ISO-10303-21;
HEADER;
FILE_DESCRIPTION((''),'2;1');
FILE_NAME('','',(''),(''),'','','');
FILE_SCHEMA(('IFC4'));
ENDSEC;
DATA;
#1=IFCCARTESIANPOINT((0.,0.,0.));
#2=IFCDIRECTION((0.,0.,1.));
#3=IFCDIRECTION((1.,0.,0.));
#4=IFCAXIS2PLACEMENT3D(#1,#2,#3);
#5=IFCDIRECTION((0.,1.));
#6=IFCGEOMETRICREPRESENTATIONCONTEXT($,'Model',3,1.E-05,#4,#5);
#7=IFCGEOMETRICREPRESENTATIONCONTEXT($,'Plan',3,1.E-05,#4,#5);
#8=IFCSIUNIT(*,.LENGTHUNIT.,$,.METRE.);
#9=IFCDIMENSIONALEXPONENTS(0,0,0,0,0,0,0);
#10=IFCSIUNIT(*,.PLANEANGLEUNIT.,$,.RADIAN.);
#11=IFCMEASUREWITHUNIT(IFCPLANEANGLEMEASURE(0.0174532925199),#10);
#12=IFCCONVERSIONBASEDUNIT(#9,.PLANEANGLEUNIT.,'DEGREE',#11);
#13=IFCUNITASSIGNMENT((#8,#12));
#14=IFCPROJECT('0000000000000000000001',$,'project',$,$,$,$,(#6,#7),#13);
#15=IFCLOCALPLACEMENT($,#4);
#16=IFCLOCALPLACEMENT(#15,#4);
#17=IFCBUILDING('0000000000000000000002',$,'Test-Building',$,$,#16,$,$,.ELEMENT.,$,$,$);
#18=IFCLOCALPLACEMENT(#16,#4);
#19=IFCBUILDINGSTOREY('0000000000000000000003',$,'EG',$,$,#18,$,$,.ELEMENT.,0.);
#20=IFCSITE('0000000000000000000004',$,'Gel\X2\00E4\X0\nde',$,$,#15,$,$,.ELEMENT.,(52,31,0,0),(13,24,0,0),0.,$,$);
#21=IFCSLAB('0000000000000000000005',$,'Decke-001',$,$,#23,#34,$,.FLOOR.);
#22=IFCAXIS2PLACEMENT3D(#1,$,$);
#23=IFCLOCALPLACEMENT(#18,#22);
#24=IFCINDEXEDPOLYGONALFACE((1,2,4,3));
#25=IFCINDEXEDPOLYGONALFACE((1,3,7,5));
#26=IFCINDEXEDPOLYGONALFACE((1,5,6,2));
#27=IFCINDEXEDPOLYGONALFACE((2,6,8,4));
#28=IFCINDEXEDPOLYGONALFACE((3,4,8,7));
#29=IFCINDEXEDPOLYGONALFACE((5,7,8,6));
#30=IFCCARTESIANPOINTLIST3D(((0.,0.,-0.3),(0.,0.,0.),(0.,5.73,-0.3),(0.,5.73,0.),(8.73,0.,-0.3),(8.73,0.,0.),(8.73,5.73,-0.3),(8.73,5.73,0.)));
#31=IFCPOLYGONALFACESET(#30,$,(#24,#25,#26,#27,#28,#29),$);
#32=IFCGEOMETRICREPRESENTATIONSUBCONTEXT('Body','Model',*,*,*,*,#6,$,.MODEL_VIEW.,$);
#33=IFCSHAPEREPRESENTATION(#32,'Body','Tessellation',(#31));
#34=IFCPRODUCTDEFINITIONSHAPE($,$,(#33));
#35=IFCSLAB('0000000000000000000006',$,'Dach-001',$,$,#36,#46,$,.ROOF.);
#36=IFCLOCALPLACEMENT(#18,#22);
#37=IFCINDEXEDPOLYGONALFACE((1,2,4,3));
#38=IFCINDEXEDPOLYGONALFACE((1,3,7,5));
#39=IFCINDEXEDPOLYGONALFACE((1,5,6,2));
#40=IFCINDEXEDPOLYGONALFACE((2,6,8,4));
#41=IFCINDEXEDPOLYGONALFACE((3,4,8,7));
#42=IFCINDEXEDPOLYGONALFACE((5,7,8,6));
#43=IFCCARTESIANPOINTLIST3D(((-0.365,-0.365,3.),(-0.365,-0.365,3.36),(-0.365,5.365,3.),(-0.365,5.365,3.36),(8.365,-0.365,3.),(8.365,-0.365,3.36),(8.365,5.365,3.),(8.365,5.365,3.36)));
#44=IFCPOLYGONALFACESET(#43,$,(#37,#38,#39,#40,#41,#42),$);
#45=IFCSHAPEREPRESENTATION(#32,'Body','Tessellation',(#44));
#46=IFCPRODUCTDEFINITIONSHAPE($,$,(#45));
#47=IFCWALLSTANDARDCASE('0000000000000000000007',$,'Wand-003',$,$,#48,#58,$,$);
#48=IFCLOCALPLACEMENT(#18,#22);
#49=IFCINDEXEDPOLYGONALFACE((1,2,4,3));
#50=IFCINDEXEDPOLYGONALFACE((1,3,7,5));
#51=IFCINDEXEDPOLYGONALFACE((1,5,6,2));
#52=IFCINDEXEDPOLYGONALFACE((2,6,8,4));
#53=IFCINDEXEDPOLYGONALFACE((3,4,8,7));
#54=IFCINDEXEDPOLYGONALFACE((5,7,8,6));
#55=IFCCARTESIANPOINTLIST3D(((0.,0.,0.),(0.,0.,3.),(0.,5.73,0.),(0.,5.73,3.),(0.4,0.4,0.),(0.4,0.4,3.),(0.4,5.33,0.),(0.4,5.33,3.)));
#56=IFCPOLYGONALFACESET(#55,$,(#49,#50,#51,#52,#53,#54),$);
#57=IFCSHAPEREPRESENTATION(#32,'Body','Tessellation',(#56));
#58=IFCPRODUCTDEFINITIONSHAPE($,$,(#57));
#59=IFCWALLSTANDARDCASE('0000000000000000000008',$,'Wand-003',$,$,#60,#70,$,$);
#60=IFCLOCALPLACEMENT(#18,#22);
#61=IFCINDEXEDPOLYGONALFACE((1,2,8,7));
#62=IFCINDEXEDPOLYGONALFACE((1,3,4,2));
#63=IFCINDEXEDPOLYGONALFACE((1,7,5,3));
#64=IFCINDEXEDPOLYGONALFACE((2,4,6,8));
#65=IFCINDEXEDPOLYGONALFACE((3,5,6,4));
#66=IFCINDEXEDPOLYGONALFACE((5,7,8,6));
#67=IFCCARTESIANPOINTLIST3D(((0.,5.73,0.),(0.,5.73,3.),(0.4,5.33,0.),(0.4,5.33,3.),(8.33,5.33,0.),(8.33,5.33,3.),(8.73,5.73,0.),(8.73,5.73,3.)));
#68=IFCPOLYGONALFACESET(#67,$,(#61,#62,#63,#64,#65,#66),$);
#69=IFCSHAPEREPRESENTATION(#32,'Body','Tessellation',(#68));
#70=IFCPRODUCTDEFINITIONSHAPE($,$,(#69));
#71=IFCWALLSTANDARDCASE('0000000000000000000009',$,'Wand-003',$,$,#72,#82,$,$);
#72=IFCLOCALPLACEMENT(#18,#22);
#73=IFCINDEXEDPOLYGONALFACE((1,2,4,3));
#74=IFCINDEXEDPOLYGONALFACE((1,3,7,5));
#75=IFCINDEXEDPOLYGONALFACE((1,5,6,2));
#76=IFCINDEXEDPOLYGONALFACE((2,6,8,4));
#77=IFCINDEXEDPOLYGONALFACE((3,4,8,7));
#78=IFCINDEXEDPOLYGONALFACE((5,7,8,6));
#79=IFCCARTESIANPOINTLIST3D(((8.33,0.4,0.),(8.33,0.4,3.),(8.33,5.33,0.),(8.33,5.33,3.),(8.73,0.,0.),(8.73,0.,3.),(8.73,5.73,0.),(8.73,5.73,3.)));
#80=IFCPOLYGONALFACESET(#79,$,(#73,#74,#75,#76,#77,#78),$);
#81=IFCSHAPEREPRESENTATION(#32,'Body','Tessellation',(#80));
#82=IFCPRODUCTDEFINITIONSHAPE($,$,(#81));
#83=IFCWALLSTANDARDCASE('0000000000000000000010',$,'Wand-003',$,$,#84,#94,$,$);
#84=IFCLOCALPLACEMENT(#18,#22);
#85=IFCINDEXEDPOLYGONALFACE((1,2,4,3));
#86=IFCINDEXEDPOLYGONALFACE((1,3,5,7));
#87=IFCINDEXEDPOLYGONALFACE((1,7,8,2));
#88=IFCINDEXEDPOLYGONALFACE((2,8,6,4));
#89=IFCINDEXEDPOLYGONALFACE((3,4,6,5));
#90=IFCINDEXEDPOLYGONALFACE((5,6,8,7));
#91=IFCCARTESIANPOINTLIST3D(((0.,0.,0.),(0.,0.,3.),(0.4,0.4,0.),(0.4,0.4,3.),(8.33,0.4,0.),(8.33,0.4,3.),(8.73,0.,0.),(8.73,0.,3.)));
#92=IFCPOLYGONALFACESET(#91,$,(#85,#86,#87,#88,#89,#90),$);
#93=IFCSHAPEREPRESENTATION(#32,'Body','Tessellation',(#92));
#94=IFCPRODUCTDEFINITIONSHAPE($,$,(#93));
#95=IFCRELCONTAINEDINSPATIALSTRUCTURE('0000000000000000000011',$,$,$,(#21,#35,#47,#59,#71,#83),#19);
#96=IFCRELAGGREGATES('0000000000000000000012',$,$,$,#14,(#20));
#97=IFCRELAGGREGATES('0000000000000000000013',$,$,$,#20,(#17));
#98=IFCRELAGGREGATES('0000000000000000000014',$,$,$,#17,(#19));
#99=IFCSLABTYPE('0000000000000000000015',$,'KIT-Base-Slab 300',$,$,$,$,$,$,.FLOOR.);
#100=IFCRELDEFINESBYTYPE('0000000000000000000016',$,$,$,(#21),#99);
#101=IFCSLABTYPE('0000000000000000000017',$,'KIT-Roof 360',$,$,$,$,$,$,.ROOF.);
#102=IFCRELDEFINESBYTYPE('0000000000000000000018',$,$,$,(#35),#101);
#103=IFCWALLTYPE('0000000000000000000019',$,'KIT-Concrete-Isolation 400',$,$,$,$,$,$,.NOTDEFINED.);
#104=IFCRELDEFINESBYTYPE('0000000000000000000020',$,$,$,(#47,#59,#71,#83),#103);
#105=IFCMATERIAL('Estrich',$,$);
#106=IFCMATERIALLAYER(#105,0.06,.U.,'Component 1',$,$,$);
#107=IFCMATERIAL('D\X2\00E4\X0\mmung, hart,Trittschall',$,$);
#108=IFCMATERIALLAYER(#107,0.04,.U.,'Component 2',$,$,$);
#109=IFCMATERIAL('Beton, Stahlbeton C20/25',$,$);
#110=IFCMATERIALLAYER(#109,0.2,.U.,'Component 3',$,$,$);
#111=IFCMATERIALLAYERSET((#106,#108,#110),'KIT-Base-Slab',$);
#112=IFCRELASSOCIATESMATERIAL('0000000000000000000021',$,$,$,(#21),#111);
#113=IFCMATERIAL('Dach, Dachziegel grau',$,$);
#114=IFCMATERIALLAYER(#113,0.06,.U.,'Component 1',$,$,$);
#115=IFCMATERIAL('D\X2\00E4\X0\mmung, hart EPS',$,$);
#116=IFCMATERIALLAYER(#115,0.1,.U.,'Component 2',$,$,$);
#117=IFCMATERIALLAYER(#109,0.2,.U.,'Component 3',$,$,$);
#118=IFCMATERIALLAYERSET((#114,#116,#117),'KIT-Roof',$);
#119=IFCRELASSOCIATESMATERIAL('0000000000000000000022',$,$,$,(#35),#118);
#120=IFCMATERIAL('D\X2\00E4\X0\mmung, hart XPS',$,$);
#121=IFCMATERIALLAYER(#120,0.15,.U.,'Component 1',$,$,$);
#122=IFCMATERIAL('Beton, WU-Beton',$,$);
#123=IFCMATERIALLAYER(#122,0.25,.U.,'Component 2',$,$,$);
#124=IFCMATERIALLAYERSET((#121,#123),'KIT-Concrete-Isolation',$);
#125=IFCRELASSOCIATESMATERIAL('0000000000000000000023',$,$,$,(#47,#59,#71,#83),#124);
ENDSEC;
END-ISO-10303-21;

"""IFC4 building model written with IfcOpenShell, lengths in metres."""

from ifc_helpers import new_model, entity, si_unit, converted_unit, direction, frame, origin_with_axes, place, context, subcontext, project, spatial, polyline, outline, extrude, material, layer, layer_set, layer_usage, type_object, element, save


model = new_model("IFC4")

# Units and contexts
model_context = context("Model", 3, precision=1e-05, world=origin_with_axes(), true_north=direction((0.0, 1.0)))
plan_context = context("Plan", 3, precision=1e-05, world=origin_with_axes(), true_north=direction((0.0, 1.0)))
body_context = subcontext(model_context, "Body", "Model", "MODEL_VIEW")
ifc_project = project(units=[si_unit("LENGTHUNIT", "METRE"), converted_unit("PLANEANGLEUNIT", "DEGREE", entity("IfcPlaneAngleMeasure", 0.0174532925199), si_unit("PLANEANGLEUNIT", "RADIAN"), dimensions=[0, 0, 0, 0, 0, 0, 0])], contexts=[model_context, plan_context])

# Site, building, storey
site_placement = place(None, origin_with_axes())
site = spatial("IfcSite", under=ifc_project, at=site_placement, Name="Gelände", CompositionType="ELEMENT", RefLatitude=(52, 31, 0, 0), RefLongitude=(13, 24, 0, 0), RefElevation=0.0)
building_placement = place(site_placement, origin_with_axes())
building = spatial("IfcBuilding", under=site, at=building_placement, Name="Test-Building", CompositionType="ELEMENT")
storey_placement = place(building_placement, origin_with_axes())
storey = spatial("IfcBuildingStorey", under=building, at=storey_placement, Name="EG", CompositionType="ELEMENT", Elevation=0.0)

# Slabs
ifc_material_1 = material(Name="Estrich")
ifc_layer_1 = layer(ifc_material_1, 0.06, ventilated="UNKNOWN", Name="Component 1")
ifc_material_2 = material(Name="Dämmung, hart,Trittschall")
ifc_layer_2 = layer(ifc_material_2, 0.04, ventilated="UNKNOWN", Name="Component 2")
ifc_material_3 = material(Name="Beton, Stahlbeton C20/25")
ifc_layer_3 = layer(ifc_material_3, 0.2, ventilated="UNKNOWN", Name="Component 3")
ifc_layer_set_1 = layer_set([ifc_layer_1, ifc_layer_2, ifc_layer_3], Name="KIT-Base-Slab")
ifc_layer_usage_1 = layer_usage(ifc_layer_set_1, "AXIS3", "NEGATIVE", 0.3)
slab_type_1 = type_object("IfcSlabType", Name="KIT-Base-Slab 300", PredefinedType="FLOOR")
slab_1_placement = place(storey_placement, origin_with_axes())
element("IfcSlab", 1, at=slab_1_placement, inside=storey, type_object=slab_type_1, material=ifc_layer_usage_1, Name="Decke-001", PredefinedType="FLOOR", context=body_context, shape_type="SweptSolid", body=[
    extrude(outline(polyline([(0.0, 0.0), (8.73, 0.0), (8.73, 5.73), (0.0, 5.73), (0.0, 0.0)])), frame((0.0, 0.0, -0.3), z_axis=(0.0, 0.0, 1.0), x_axis=(1.0, 0.0, 0.0)), (0.0, 0.0, 1.0), 0.3),
])
ifc_material_4 = material(Name="Dach, Dachziegel grau")
ifc_layer_4 = layer(ifc_material_4, 0.06, ventilated="UNKNOWN", Name="Component 1")
ifc_material_5 = material(Name="Dämmung, hart EPS")
ifc_layer_5 = layer(ifc_material_5, 0.1, ventilated="UNKNOWN", Name="Component 2")
ifc_layer_6 = layer(ifc_material_3, 0.2, ventilated="UNKNOWN", Name="Component 3")
ifc_layer_set_2 = layer_set([ifc_layer_4, ifc_layer_5, ifc_layer_6], Name="KIT-Roof")
ifc_layer_usage_2 = layer_usage(ifc_layer_set_2, "AXIS3", "NEGATIVE", 0.36)
slab_type_2 = type_object("IfcSlabType", Name="KIT-Roof 360", PredefinedType="ROOF")
slab_2_placement = place(storey_placement, frame((-0.365, -0.365, 3.0), z_axis=(0.0, 0.0, 1.0), x_axis=(1.0, 0.0, 0.0)))
element("IfcSlab", 2, at=slab_2_placement, inside=storey, type_object=slab_type_2, material=ifc_layer_usage_2, Name="Dach-001", PredefinedType="ROOF", context=body_context, shape_type="SweptSolid", body=[
    extrude(outline(polyline([(0.0, 0.0), (8.73, 0.0), (8.73, 5.73), (0.0, 5.73), (0.0, 0.0)])), origin_with_axes(), (0.0, 0.0, 1.0), 0.36),
])

# Walls
ifc_material_6 = material(Name="Dämmung, hart XPS")
ifc_layer_7 = layer(ifc_material_6, 0.15, ventilated="UNKNOWN", Name="Component 1")
ifc_material_7 = material(Name="Beton, WU-Beton")
ifc_layer_8 = layer(ifc_material_7, 0.25, ventilated="UNKNOWN", Name="Component 2")
ifc_layer_set_3 = layer_set([ifc_layer_7, ifc_layer_8], Name="KIT-Concrete-Isolation")
ifc_layer_usage_3 = layer_usage(ifc_layer_set_3, "AXIS2", "NEGATIVE", 0.0)
wall_type = type_object("IfcWallType", Name="KIT-Concrete-Isolation 400", PredefinedType="NOTDEFINED")
wall_1_placement = place(storey_placement, frame((0.0, 0.0, 0.0), z_axis=(0.0, 0.0, 1.0), x_axis=(0.0, 1.0, 0.0)))
element("IfcWallStandardCase", 3, at=wall_1_placement, inside=storey, type_object=wall_type, material=ifc_layer_usage_3, Name="Wand-003", context=body_context, shape_type="SweptSolid", body=[
    extrude(outline(polyline([(0.4, -0.4), (5.33, -0.4), (5.73, 0.0), (0.0, 0.0), (0.4, -0.4)])), origin_with_axes(), (0.0, 0.0, 1.0), 3.0),
])
ifc_layer_usage_4 = layer_usage(ifc_layer_set_3, "AXIS2", "NEGATIVE", 0.0)
wall_2_placement = place(storey_placement, frame((0.0, 5.73, 0.0), z_axis=(0.0, 0.0, 1.0), x_axis=(1.0, 0.0, 0.0)))
element("IfcWallStandardCase", 4, at=wall_2_placement, inside=storey, type_object=wall_type, material=ifc_layer_usage_4, Name="Wand-003", context=body_context, shape_type="SweptSolid", body=[
    extrude(outline(polyline([(0.4, -0.4), (8.33, -0.4), (8.73, 0.0), (0.0, 0.0), (0.4, -0.4)])), origin_with_axes(), (0.0, 0.0, 1.0), 3.0),
])
ifc_layer_usage_5 = layer_usage(ifc_layer_set_3, "AXIS2", "NEGATIVE", 0.0)
wall_3_placement = place(storey_placement, frame((8.73, 5.73, 0.0), z_axis=(0.0, 0.0, 1.0), x_axis=(0.0, -1.0, 0.0)))
element("IfcWallStandardCase", 5, at=wall_3_placement, inside=storey, type_object=wall_type, material=ifc_layer_usage_5, Name="Wand-003", context=body_context, shape_type="SweptSolid", body=[
    extrude(outline(polyline([(0.4, -0.4), (5.33, -0.4), (5.73, 0.0), (0.0, 0.0), (0.4, -0.4)])), origin_with_axes(), (0.0, 0.0, 1.0), 3.0),
])
ifc_layer_usage_6 = layer_usage(ifc_layer_set_3, "AXIS2", "NEGATIVE", 0.0)
wall_4_placement = place(storey_placement, frame((8.73, 0.0, 0.0), z_axis=(0.0, 0.0, 1.0), x_axis=(-1.0, 0.0, 0.0)))
element("IfcWallStandardCase", 6, at=wall_4_placement, inside=storey, type_object=wall_type, material=ifc_layer_usage_6, Name="Wand-003", context=body_context, shape_type="SweptSolid", body=[
    extrude(outline(polyline([(0.4, -0.4), (8.33, -0.4), (8.73, 0.0), (0.0, 0.0), (0.4, -0.4)])), origin_with_axes(), (0.0, 0.0, 1.0), 3.0),
])

save(model, "model.ifc")
